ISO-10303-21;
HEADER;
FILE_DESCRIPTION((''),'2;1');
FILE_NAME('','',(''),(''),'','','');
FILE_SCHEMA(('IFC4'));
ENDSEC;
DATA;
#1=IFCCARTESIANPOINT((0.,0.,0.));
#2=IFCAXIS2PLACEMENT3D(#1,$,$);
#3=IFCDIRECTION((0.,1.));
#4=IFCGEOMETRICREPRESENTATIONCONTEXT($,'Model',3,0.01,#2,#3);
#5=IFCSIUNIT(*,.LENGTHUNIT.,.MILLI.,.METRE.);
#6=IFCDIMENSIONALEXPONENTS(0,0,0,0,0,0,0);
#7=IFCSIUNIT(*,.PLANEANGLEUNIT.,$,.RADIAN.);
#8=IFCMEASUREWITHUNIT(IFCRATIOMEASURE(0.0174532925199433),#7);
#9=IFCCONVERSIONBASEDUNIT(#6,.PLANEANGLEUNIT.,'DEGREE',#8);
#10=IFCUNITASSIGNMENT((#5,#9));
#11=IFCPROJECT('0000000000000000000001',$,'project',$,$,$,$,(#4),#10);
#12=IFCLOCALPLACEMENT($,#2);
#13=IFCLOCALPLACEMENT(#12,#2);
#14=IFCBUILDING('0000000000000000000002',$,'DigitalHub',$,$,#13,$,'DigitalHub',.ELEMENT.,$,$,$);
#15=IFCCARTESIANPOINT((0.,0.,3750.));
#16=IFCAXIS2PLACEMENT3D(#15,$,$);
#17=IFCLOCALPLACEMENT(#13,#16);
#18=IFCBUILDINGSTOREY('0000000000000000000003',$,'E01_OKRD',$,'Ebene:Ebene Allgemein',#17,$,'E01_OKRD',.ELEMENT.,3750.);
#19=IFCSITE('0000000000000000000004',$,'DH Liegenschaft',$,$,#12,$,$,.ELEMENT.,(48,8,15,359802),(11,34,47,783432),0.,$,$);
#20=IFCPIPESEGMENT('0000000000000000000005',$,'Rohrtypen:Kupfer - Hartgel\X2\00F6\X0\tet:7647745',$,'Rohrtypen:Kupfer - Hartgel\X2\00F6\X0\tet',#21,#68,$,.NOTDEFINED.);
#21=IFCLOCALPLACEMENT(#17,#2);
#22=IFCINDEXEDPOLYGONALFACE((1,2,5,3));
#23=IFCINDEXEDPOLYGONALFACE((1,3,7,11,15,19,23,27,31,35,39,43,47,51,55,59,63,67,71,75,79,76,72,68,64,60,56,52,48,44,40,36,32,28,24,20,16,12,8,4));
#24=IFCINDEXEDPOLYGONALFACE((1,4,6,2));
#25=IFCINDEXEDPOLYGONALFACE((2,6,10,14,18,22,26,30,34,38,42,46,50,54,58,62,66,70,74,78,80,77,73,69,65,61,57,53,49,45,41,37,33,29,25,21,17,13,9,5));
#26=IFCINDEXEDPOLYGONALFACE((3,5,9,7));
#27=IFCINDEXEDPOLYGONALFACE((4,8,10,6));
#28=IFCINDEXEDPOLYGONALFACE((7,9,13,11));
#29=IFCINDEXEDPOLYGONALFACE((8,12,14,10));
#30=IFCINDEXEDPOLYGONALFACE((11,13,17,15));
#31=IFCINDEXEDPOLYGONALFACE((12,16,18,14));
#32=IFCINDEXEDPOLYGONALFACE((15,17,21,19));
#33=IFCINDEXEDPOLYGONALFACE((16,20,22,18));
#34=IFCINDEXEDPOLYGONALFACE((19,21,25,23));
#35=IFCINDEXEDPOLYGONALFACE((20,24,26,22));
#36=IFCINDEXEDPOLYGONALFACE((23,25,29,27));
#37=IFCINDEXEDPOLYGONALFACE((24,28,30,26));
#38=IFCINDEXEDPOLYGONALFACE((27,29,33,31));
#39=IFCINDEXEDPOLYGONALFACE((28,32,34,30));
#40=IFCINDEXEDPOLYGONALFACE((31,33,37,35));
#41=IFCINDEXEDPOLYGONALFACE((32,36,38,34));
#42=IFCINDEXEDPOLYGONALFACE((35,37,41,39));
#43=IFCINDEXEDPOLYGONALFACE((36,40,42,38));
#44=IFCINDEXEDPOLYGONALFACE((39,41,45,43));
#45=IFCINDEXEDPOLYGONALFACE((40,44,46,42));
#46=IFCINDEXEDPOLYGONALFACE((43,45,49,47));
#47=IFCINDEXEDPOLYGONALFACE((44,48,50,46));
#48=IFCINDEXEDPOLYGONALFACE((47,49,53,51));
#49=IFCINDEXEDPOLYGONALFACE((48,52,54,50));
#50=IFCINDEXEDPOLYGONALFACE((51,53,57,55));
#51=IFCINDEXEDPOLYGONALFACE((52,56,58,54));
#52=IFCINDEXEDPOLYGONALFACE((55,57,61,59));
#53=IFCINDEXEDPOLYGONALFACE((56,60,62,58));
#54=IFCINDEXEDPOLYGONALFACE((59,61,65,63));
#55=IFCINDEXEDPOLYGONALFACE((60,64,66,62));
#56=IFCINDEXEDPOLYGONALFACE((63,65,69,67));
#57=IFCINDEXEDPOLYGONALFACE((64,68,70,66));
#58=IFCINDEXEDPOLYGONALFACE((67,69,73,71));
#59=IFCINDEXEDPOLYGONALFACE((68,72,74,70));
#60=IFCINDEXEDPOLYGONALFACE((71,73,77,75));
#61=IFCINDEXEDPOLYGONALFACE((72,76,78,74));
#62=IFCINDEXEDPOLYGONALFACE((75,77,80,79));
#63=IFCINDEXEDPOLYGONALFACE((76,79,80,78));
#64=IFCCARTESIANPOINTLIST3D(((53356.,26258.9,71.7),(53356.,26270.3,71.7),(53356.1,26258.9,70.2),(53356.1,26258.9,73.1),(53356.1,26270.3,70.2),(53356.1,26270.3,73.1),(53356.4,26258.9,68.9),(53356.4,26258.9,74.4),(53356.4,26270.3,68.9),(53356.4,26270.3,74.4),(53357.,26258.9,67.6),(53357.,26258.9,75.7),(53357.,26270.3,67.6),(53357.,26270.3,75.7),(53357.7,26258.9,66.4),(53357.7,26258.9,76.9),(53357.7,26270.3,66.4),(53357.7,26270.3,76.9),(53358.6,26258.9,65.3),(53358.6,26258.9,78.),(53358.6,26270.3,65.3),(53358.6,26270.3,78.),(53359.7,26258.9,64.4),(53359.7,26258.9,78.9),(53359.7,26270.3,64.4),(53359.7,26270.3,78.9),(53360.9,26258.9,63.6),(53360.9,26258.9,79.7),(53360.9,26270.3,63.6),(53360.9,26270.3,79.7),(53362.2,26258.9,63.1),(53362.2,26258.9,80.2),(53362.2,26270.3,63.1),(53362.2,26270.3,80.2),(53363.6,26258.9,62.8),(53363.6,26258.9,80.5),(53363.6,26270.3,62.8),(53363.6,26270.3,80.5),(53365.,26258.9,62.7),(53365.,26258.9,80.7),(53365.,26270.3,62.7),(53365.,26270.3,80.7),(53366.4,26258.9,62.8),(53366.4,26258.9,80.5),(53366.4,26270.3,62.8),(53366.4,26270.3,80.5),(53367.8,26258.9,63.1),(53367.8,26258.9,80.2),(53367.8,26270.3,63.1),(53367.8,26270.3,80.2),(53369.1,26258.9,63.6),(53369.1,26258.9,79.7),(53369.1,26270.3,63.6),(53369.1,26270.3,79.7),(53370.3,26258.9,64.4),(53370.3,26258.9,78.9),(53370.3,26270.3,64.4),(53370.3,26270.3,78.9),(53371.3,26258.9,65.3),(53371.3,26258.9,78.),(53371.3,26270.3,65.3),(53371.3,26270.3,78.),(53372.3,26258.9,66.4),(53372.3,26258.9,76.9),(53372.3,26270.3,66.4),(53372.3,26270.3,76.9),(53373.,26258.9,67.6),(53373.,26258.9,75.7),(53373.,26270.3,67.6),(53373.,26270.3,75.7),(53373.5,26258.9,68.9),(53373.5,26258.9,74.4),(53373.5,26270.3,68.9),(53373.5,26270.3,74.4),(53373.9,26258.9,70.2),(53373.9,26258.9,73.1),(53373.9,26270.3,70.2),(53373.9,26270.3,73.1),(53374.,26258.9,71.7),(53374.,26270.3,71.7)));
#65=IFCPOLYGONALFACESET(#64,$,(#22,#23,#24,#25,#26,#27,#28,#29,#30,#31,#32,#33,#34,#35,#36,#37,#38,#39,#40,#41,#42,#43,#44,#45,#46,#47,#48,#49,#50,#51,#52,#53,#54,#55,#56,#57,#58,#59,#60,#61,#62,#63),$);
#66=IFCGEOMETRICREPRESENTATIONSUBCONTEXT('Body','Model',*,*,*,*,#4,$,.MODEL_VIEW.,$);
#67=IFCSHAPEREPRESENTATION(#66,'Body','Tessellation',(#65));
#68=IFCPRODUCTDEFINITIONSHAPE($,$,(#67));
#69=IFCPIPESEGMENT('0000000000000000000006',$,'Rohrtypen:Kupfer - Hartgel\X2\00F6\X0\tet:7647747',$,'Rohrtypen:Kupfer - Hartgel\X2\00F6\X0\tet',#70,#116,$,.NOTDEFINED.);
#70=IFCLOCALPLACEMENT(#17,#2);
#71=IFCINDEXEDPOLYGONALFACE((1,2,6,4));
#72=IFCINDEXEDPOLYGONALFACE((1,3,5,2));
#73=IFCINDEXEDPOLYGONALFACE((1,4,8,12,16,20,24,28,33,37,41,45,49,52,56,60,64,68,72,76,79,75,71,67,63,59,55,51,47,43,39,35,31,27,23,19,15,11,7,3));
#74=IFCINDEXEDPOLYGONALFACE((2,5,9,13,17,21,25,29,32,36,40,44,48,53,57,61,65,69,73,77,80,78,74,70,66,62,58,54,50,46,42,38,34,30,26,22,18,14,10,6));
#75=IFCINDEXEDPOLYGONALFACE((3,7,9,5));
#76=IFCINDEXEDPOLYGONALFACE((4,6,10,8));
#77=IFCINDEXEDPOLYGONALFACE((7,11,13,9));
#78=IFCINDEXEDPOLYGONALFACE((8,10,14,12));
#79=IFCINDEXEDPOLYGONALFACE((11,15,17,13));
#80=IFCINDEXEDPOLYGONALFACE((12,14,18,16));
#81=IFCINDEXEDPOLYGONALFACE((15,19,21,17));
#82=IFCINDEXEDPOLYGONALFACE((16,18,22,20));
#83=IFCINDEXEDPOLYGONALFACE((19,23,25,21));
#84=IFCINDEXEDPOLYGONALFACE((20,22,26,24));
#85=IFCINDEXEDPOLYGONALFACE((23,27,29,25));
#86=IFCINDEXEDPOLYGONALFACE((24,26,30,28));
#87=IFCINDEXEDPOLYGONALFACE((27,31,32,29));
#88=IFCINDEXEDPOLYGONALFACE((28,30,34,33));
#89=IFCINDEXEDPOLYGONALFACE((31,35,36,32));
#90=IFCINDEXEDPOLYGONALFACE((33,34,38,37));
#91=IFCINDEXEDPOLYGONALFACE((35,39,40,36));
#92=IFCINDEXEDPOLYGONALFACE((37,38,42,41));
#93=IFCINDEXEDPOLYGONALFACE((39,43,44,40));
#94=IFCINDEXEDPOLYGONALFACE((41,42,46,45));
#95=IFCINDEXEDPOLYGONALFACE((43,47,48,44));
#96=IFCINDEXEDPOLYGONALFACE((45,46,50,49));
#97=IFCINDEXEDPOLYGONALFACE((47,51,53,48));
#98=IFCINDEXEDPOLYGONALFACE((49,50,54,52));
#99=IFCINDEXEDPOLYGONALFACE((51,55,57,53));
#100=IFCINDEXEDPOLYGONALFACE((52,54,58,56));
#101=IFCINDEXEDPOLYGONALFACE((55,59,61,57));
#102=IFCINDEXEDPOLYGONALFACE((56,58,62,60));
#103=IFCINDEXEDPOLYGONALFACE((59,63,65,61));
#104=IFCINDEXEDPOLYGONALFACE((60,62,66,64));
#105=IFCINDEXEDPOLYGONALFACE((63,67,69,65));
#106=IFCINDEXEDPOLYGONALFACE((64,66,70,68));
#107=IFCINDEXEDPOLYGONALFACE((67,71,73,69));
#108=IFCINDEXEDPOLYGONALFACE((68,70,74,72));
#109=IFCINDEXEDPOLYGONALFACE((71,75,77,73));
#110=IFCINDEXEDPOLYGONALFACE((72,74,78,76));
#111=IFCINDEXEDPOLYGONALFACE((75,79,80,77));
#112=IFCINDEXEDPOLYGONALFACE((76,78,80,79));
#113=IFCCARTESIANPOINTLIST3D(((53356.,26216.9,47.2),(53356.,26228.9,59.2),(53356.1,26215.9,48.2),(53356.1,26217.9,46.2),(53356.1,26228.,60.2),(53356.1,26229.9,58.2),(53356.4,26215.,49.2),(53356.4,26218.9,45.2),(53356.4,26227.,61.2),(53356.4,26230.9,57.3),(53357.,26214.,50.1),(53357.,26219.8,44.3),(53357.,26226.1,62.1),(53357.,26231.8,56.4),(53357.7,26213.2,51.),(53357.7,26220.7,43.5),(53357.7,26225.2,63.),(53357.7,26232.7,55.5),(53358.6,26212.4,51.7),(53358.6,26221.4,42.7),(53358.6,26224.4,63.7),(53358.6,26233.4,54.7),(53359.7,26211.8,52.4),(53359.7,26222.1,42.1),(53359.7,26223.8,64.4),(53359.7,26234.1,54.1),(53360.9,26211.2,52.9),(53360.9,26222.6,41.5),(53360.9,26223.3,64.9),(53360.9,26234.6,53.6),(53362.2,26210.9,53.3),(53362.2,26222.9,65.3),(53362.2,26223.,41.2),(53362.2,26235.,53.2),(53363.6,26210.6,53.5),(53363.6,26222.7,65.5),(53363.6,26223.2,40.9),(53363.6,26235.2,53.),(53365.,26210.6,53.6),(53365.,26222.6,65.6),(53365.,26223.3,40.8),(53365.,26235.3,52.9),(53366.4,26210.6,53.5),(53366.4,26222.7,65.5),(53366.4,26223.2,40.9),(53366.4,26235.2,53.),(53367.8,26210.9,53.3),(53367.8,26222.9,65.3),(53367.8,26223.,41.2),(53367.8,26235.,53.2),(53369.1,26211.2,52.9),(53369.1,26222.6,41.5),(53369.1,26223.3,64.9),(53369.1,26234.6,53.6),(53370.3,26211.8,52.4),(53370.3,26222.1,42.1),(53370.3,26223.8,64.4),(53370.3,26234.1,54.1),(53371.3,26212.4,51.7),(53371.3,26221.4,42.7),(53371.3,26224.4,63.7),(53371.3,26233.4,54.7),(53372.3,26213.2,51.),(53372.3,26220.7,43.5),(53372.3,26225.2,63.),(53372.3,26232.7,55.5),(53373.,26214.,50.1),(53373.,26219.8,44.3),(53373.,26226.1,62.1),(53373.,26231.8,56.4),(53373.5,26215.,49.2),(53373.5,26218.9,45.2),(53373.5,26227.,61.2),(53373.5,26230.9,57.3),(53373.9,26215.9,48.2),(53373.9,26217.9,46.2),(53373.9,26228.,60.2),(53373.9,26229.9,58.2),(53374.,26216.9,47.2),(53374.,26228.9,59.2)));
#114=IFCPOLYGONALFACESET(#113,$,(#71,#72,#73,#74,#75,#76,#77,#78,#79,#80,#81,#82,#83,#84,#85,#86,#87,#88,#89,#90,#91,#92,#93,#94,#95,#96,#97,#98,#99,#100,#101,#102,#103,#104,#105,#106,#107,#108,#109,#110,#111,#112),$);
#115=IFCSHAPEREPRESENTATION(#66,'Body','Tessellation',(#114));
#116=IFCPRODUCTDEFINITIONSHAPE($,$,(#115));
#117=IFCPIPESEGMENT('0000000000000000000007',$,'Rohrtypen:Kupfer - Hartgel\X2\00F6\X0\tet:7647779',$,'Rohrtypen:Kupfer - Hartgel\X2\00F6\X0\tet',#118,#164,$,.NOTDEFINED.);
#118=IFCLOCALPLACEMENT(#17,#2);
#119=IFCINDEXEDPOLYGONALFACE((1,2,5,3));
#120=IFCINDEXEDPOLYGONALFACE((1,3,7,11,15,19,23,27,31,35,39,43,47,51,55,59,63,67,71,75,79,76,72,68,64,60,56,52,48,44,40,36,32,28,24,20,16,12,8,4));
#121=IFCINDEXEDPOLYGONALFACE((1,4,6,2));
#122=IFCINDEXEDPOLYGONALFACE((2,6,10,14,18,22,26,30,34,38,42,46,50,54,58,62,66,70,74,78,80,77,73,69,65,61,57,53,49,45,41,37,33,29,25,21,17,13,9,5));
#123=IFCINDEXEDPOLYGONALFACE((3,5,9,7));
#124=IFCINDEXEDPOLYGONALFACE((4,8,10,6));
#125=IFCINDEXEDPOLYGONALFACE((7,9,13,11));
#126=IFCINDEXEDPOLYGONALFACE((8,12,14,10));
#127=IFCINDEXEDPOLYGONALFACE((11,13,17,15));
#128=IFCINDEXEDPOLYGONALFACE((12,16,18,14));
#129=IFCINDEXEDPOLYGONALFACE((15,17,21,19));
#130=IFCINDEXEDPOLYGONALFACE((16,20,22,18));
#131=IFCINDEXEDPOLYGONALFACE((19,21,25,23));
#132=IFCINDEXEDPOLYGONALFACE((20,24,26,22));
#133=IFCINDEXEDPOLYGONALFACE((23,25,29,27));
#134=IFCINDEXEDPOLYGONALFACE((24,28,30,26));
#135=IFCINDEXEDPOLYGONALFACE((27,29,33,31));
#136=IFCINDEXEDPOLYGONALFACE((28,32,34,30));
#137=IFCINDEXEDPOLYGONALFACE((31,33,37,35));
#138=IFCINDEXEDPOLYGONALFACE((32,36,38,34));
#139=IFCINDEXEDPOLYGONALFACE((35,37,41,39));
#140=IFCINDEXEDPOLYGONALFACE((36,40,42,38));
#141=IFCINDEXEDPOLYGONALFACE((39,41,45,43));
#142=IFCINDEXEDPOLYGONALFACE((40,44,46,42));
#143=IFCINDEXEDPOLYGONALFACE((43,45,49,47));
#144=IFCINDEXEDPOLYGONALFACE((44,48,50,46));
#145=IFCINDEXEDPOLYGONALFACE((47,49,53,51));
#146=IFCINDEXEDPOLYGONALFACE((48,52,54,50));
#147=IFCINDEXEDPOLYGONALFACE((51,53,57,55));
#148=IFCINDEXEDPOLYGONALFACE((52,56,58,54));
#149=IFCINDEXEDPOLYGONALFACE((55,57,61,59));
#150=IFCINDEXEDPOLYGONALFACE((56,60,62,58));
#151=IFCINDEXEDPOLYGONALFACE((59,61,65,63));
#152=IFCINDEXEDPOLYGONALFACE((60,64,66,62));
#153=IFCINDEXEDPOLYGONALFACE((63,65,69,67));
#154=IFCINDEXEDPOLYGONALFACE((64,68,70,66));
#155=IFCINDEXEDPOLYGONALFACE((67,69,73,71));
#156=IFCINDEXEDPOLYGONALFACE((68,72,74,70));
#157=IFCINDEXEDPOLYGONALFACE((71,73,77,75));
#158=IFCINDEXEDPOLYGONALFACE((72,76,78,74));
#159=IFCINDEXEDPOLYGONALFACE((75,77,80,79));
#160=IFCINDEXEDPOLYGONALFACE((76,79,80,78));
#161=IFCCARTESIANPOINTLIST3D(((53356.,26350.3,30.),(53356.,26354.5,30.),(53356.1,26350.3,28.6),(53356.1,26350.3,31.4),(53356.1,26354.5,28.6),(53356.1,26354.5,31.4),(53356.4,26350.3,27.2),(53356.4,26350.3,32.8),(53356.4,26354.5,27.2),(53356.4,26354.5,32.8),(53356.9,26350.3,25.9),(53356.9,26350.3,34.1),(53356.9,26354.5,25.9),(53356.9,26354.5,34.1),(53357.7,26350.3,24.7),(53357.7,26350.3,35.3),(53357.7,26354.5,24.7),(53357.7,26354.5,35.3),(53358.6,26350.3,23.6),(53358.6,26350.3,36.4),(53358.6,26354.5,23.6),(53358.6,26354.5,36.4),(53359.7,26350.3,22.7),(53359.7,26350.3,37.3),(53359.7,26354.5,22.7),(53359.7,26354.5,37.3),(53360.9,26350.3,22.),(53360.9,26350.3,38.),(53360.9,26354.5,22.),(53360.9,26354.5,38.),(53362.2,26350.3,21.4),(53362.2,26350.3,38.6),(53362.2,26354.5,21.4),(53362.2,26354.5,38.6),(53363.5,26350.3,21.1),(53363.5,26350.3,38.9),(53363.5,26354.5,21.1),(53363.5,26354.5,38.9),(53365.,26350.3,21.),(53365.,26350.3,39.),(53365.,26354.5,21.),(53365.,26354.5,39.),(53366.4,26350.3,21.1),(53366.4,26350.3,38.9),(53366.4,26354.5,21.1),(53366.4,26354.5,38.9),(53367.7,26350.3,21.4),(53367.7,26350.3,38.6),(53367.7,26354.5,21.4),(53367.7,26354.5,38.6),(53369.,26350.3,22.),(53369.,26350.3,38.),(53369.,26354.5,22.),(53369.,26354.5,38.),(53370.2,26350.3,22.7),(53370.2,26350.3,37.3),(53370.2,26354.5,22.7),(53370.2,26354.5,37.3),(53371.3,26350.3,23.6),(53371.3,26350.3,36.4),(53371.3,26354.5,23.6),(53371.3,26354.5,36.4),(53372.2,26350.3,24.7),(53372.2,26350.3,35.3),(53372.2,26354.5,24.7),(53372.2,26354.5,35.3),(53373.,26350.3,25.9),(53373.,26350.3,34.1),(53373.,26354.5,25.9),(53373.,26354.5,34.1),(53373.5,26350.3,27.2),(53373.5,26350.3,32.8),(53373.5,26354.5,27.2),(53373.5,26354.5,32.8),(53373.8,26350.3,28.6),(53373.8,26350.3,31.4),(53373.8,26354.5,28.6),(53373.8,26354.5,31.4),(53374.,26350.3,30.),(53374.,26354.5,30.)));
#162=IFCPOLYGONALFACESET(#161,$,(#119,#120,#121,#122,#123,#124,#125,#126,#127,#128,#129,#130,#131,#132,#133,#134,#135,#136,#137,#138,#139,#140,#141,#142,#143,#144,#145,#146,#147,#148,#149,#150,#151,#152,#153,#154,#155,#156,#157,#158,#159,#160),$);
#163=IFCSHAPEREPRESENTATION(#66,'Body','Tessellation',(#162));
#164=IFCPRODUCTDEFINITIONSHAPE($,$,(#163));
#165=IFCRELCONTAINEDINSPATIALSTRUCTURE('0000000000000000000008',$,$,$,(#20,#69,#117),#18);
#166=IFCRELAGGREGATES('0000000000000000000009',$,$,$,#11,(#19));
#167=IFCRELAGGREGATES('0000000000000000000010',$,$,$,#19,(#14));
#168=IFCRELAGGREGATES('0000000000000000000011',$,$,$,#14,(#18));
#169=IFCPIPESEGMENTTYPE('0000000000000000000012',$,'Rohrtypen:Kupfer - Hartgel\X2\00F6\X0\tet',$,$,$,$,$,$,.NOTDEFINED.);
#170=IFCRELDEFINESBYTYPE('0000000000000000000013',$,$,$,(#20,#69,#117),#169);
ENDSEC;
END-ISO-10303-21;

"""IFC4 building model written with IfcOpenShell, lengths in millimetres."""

from ifc_helpers import new_model, entity, si_unit, converted_unit, direction, frame, origin, place, context, subcontext, project, spatial, indexed_curve, outline, extrude, type_object, element, save


model = new_model("IFC4")

# Units and contexts
model_context = context("Model", 3, precision=0.01, world=origin(), true_north=direction((0.0, 1.0)))
body_context = subcontext(model_context, "Body", "Model", "MODEL_VIEW")
ifc_project = project(units=[si_unit("LENGTHUNIT", "METRE", prefix="MILLI"), converted_unit("PLANEANGLEUNIT", "DEGREE", entity("IfcRatioMeasure", 0.0174532925199433), si_unit("PLANEANGLEUNIT", "RADIAN"), dimensions=[0, 0, 0, 0, 0, 0, 0])], contexts=[model_context])

# Site, building, storey
site_placement = place(None, origin())
site = spatial("IfcSite", under=ifc_project, at=site_placement, Name="DH Liegenschaft", CompositionType="ELEMENT", RefLatitude=(48, 8, 15, 359802), RefLongitude=(11, 34, 47, 783432), RefElevation=0.0)
building_placement = place(site_placement, origin())
building = spatial("IfcBuilding", under=site, at=building_placement, Name="DigitalHub", LongName="DigitalHub", CompositionType="ELEMENT")
storey_placement = place(building_placement, frame((0.0, 0.0, 3750.0)))
storey = spatial("IfcBuildingStorey", under=building, at=storey_placement, Name="E01_OKRD", ObjectType="Ebene:Ebene Allgemein", LongName="E01_OKRD", CompositionType="ELEMENT", Elevation=3750.0)

# Pipe segments
pipe_segment_type = type_object("IfcPipeSegmentType", Name="Rohrtypen:Kupfer - Hartgelötet", PredefinedType="NOTDEFINED")
pipe_segment_1_placement = place(storey_placement, frame((53354.4, 26258.9, 61.1)))
element("IfcPipeSegment", 1, at=pipe_segment_1_placement, inside=storey, type_object=pipe_segment_type, Name="Rohrtypen:Kupfer - Hartgelötet:7647745", ObjectType="Rohrtypen:Kupfer - Hartgelötet", PredefinedType="NOTDEFINED", context=body_context, shape_type="SweptSolid", body=[
    extrude(outline(indexed_curve([(9.0, 0.0), (8.9, 1.4), (8.6, 2.8), (8.0, 4.1), (7.3, 5.3), (6.4, 6.4), (5.3, 7.3), (4.1, 8.0), (2.8, 8.6), (1.4, 8.9), (0.0, 9.0), (-1.4, 8.9), (-2.8, 8.6), (-4.1, 8.0), (-5.3, 7.3), (-6.4, 6.4), (-7.3, 5.3), (-8.0, 4.1), (-8.6, 2.8), (-8.9, 1.4), (-9.0, 0.0), (-8.9, -1.4), (-8.6, -2.8), (-8.0, -4.1), (-7.3, -5.3), (-6.4, -6.4), (-5.3, -7.3), (-4.1, -8.0), (-2.8, -8.6), (-1.4, -8.9), (0.0, -9.0), (1.4, -8.9), (2.8, -8.6), (4.1, -8.0), (5.3, -7.3), (6.4, -6.4), (7.3, -5.3), (8.0, -4.1), (8.6, -2.8), (8.9, -1.4), (9.0, 0.0)], self_intersect=False)), frame((10.6, 0.0, 10.6), z_axis=(0.000048, 1.0, 0.000305), x_axis=(-1.0, 0.000048, 0.0)), (0.0, 0.0, 1.0), 11.4),
])
pipe_segment_2_placement = place(storey_placement, frame((53354.4, 26209.0, 39.3)))
element("IfcPipeSegment", 2, at=pipe_segment_2_placement, inside=storey, type_object=pipe_segment_type, Name="Rohrtypen:Kupfer - Hartgelötet:7647747", ObjectType="Rohrtypen:Kupfer - Hartgelötet", PredefinedType="NOTDEFINED", context=body_context, shape_type="SweptSolid", body=[
    extrude(outline(indexed_curve([(9.0, 0.0), (8.9, 1.4), (8.6, 2.8), (8.0, 4.1), (7.3, 5.3), (6.4, 6.4), (5.3, 7.3), (4.1, 8.0), (2.8, 8.6), (1.4, 8.9), (0.0, 9.0), (-1.4, 8.9), (-2.8, 8.6), (-4.1, 8.0), (-5.3, 7.3), (-6.4, 6.4), (-7.3, 5.3), (-8.0, 4.1), (-8.6, 2.8), (-8.9, 1.4), (-9.0, 0.0), (-8.9, -1.4), (-8.6, -2.8), (-8.0, -4.1), (-7.3, -5.3), (-6.4, -6.4), (-5.3, -7.3), (-4.1, -8.0), (-2.8, -8.6), (-1.4, -8.9), (0.0, -9.0), (1.4, -8.9), (2.8, -8.6), (4.1, -8.0), (5.3, -7.3), (6.4, -6.4), (7.3, -5.3), (8.0, -4.1), (8.6, -2.8), (8.9, -1.4), (9.0, 0.0)], self_intersect=False)), frame((10.6, 8.0, 8.0), z_axis=(0.0, 0.707107, 0.707107), x_axis=(-1.0, 0.0, 0.0)), (0.0, 0.0, 1.0), 17.0),
])
pipe_segment_3_placement = place(storey_placement, frame((53354.4, 26350.3, 19.4)))
element("IfcPipeSegment", 3, at=pipe_segment_3_placement, inside=storey, type_object=pipe_segment_type, Name="Rohrtypen:Kupfer - Hartgelötet:7647779", ObjectType="Rohrtypen:Kupfer - Hartgelötet", PredefinedType="NOTDEFINED", context=body_context, shape_type="SweptSolid", body=[
    extrude(outline(indexed_curve([(9.0, 0.0), (8.9, 1.4), (8.6, 2.8), (8.0, 4.1), (7.3, 5.3), (6.4, 6.4), (5.3, 7.3), (4.1, 8.0), (2.8, 8.6), (1.4, 8.9), (0.0, 9.0), (-1.4, 8.9), (-2.8, 8.6), (-4.1, 8.0), (-5.3, 7.3), (-6.4, 6.4), (-7.3, 5.3), (-8.0, 4.1), (-8.6, 2.8), (-8.9, 1.4), (-9.0, 0.0), (-8.9, -1.4), (-8.6, -2.8), (-8.0, -4.1), (-7.3, -5.3), (-6.4, -6.4), (-5.3, -7.3), (-4.1, -8.0), (-2.8, -8.6), (-1.4, -8.9), (0.0, -9.0), (1.4, -8.9), (2.8, -8.6), (4.1, -8.0), (5.3, -7.3), (6.4, -6.4), (7.3, -5.3), (8.0, -4.1), (8.6, -2.8), (8.9, -1.4), (9.0, 0.0)], self_intersect=False)), frame((10.6, 0.0, 10.6), z_axis=(0.0, 1.0, 0.0), x_axis=(1.0, 0.0, 0.0)), (0.0, 0.0, 1.0), 4.2),
])

save(model, "model.ifc")
